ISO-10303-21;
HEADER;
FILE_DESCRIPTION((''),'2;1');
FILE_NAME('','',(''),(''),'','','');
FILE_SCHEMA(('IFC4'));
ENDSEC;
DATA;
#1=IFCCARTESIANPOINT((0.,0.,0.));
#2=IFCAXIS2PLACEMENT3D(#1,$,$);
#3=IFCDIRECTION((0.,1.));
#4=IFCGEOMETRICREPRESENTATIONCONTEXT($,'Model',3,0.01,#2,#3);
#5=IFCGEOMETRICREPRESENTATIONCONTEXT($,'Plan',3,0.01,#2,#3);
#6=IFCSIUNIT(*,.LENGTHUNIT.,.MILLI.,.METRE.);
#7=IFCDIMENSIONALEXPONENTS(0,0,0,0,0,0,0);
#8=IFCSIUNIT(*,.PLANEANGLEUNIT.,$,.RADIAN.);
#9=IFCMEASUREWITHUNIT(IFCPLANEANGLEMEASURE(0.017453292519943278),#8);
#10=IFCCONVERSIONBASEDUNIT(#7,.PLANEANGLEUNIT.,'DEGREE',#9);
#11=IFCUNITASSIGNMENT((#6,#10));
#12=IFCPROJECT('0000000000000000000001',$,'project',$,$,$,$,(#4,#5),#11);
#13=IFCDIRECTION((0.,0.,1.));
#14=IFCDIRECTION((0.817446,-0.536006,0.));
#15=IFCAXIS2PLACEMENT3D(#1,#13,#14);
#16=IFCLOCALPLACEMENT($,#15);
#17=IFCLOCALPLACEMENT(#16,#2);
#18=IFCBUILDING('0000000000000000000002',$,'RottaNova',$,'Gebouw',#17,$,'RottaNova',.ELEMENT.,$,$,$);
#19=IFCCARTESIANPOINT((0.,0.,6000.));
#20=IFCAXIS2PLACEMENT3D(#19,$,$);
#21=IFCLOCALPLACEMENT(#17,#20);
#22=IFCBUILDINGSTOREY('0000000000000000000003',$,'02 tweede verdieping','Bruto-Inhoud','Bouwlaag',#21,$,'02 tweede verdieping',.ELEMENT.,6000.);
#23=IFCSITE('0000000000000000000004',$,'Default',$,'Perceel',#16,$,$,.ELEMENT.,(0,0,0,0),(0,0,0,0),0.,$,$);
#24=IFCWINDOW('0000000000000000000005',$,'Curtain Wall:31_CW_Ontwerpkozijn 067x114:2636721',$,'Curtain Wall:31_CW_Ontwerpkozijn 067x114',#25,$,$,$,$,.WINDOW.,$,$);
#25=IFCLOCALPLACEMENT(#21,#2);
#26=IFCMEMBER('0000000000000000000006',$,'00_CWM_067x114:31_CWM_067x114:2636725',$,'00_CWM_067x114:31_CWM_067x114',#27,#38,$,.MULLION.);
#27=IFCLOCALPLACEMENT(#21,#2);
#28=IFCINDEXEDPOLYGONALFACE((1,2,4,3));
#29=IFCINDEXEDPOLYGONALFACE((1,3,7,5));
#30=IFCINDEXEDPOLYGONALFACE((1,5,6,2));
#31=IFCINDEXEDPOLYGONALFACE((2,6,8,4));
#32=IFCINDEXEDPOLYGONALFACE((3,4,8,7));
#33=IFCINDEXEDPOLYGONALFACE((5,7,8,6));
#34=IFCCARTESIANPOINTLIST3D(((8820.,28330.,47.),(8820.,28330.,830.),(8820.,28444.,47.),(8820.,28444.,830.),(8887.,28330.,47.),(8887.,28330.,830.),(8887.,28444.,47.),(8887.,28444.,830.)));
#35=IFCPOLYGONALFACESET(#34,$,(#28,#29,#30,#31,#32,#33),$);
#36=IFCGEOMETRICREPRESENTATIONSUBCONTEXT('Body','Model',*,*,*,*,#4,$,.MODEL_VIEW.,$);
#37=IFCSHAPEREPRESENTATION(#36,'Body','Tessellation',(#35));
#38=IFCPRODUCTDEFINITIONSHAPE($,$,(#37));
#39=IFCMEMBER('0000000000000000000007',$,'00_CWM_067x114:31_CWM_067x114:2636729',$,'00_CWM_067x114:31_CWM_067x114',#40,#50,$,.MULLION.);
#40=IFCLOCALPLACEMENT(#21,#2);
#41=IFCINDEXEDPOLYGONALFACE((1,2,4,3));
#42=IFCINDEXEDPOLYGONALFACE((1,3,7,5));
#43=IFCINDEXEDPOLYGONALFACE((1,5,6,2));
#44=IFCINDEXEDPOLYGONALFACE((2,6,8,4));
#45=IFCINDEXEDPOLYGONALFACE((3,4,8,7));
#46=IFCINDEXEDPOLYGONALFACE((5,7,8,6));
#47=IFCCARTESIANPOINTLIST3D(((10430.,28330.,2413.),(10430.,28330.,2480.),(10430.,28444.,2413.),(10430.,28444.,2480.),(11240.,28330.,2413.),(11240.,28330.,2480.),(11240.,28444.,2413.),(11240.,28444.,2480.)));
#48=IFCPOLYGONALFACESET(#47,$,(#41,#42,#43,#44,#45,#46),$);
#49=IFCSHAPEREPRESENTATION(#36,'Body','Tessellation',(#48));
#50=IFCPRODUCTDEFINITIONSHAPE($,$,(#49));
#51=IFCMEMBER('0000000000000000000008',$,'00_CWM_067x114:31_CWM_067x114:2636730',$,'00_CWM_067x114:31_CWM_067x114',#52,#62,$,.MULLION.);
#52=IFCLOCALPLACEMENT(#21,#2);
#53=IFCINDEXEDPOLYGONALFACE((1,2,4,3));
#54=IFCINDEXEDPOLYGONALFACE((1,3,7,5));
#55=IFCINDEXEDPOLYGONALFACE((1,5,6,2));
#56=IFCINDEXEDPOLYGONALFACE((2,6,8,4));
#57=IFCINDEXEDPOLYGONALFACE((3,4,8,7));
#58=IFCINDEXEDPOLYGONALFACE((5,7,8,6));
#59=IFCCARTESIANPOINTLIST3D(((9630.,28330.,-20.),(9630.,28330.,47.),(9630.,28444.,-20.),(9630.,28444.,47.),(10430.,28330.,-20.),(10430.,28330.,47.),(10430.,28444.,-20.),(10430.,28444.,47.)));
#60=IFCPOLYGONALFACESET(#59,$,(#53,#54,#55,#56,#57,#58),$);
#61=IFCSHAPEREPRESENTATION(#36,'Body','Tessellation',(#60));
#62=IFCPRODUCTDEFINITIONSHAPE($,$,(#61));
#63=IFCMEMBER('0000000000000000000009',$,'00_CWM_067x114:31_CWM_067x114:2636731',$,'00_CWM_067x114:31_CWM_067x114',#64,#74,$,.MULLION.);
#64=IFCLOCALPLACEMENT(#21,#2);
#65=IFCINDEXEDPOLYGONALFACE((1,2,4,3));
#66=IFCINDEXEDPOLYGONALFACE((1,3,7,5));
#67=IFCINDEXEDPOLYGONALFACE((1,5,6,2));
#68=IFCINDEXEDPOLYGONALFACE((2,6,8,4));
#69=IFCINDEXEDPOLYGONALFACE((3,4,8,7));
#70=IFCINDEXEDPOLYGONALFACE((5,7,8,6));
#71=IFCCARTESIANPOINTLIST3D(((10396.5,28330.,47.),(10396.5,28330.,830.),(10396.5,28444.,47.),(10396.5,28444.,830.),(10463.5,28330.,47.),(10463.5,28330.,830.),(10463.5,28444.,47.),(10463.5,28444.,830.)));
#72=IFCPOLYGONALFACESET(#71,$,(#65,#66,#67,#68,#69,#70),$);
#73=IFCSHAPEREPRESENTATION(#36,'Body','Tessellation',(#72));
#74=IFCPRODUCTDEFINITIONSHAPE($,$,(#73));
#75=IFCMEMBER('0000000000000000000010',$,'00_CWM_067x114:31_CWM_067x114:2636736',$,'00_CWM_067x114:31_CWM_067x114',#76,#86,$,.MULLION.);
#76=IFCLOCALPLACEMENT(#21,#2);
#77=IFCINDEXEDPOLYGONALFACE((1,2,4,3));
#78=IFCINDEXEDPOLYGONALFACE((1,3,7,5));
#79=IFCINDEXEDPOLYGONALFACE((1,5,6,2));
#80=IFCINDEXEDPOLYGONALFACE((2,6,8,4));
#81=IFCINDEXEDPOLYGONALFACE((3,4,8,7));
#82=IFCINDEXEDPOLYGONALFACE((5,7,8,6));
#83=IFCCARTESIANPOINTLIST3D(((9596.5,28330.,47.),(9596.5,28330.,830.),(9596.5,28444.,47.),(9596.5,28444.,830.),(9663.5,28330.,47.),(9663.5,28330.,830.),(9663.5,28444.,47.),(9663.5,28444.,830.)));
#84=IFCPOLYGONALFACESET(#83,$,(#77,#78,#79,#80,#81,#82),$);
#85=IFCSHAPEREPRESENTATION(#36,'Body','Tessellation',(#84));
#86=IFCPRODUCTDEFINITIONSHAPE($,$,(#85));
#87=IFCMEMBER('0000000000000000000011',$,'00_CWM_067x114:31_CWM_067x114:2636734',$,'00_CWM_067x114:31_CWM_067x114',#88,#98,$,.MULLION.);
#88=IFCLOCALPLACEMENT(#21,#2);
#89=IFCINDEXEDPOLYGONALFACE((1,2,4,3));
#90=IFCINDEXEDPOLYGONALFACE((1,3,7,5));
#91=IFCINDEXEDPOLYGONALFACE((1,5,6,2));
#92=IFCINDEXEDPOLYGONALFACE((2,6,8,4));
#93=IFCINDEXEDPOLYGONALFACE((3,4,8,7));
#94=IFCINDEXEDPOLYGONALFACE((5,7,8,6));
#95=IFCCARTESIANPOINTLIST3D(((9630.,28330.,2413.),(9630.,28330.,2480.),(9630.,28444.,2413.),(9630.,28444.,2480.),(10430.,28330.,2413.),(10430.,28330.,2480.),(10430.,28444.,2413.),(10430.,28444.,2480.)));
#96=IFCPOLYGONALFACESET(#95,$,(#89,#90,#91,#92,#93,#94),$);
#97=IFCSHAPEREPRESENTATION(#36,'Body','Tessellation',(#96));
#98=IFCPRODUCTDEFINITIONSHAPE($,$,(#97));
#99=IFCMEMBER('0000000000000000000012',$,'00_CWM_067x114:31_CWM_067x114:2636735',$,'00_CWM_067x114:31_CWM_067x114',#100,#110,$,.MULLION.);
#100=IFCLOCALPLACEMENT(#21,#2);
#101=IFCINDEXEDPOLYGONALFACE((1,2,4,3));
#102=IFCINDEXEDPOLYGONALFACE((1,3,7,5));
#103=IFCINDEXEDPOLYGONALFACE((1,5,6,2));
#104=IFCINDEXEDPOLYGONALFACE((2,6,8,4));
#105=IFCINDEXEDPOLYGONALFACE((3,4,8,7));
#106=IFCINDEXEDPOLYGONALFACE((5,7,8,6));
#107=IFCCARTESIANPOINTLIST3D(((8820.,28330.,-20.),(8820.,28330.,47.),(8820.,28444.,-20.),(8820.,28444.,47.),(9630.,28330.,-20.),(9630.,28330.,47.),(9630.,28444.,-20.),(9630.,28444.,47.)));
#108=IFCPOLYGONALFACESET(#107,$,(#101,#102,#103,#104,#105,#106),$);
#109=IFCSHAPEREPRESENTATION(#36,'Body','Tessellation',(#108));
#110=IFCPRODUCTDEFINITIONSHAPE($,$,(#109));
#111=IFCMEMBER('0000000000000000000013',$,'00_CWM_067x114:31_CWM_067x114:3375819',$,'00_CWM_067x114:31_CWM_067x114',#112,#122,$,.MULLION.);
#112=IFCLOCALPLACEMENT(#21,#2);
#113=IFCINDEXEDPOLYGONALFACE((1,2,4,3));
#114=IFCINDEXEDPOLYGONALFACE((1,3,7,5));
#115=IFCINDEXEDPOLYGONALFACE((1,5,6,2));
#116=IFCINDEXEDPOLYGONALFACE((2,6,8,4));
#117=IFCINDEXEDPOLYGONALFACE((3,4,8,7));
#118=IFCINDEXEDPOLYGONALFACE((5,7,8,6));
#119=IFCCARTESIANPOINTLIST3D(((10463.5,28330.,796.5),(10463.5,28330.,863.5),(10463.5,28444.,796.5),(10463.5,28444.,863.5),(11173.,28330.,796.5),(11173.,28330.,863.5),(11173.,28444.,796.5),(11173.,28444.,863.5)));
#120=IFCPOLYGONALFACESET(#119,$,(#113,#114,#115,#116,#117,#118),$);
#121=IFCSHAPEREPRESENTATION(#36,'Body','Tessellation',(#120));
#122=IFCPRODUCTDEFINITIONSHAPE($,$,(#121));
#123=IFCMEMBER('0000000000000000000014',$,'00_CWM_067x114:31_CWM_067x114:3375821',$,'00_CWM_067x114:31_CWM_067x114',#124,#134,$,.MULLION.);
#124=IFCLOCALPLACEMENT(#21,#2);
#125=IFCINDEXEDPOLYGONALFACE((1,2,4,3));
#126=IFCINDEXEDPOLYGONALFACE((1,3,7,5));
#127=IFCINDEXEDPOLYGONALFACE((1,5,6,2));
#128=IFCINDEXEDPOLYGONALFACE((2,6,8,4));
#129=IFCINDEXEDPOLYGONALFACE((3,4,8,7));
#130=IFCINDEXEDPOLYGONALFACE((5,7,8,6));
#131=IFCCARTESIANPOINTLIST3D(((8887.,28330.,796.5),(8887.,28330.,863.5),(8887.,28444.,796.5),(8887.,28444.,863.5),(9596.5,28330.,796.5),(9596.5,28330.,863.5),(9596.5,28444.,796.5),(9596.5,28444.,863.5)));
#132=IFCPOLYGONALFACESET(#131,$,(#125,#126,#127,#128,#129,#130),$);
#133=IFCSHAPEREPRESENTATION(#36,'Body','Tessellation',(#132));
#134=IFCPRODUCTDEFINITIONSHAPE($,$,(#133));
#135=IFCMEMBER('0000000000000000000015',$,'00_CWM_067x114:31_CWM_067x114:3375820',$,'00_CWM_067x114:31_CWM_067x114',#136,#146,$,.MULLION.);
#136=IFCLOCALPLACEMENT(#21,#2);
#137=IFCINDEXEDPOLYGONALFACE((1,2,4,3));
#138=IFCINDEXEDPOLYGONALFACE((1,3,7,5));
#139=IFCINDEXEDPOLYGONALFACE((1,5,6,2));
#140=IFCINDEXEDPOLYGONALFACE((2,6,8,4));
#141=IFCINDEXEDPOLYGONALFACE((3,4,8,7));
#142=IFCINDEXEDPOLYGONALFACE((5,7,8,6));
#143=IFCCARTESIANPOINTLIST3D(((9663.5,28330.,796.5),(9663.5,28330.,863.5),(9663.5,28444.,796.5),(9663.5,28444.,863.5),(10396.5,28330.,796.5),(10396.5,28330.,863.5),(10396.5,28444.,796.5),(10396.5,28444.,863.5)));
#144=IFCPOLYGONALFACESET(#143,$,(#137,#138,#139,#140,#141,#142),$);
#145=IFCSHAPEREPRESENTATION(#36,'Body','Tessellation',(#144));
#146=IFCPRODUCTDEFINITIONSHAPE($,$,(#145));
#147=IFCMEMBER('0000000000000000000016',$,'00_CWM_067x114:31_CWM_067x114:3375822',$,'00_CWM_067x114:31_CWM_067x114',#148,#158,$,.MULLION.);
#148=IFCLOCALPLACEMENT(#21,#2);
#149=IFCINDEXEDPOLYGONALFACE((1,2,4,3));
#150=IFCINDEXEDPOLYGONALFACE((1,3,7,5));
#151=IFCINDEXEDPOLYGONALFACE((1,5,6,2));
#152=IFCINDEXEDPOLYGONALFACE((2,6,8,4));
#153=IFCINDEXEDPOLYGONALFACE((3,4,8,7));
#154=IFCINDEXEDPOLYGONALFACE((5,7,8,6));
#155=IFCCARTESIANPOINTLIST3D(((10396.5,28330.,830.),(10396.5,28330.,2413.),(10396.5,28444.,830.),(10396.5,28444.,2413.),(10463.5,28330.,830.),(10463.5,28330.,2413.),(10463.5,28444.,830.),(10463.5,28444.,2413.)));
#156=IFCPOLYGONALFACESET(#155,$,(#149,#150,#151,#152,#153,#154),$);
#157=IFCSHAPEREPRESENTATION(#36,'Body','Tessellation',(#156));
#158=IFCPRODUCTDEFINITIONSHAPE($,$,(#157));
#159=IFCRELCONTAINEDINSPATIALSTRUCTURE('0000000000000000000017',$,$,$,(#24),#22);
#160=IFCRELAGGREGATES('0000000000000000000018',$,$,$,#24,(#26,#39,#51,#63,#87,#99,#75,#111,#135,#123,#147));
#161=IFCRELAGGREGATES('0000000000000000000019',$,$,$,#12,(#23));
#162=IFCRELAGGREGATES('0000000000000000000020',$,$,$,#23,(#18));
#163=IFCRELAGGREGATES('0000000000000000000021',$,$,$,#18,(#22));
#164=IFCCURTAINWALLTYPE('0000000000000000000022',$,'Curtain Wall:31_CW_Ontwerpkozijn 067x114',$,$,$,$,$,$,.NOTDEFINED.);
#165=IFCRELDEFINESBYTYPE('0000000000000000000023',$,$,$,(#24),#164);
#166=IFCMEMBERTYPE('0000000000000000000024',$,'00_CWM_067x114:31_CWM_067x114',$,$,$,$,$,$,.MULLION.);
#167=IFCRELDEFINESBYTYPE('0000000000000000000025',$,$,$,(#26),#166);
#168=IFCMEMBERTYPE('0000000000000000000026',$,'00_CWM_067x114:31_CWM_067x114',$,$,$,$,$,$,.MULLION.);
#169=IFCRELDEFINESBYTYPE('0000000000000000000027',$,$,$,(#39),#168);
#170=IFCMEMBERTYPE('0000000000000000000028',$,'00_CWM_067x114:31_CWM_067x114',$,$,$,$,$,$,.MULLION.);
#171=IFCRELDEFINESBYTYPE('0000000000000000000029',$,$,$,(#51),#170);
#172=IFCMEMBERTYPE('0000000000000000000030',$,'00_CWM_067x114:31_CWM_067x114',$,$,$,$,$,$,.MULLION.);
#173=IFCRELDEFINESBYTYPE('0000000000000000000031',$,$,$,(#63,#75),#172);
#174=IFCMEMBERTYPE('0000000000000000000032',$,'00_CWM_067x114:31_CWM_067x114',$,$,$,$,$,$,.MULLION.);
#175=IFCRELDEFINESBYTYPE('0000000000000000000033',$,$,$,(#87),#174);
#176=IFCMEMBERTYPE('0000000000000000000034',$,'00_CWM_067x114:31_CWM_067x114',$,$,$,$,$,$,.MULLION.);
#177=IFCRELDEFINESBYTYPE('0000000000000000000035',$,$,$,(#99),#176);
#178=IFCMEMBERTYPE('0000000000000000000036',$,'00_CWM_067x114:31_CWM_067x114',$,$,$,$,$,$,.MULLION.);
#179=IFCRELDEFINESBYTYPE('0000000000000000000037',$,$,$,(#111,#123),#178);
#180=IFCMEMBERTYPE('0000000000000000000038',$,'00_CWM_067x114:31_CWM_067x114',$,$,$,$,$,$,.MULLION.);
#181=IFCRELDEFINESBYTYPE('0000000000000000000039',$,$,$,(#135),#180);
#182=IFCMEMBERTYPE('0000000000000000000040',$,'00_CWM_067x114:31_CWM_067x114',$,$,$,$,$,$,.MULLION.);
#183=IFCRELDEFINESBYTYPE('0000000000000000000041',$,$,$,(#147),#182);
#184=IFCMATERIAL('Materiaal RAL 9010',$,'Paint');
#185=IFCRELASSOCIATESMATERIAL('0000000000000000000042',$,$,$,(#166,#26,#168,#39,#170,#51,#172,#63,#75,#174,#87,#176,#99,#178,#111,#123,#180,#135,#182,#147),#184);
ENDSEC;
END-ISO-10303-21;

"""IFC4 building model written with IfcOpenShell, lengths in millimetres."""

from ifc_helpers import new_model, entity, si_unit, converted_unit, direction, frame, origin, place, context, subcontext, project, spatial, indexed_curve, outline, extrude, source, transform, mapped, material, type_object, type_shapes, element, aggregate, save


model = new_model("IFC4")

# Units and contexts
model_context = context("Model", 3, precision=0.01, world=origin(), true_north=direction((0.0, 1.0)))
plan_context = context("Plan", 3, precision=0.01, world=origin(), true_north=direction((0.0, 1.0)))
body_context = subcontext(model_context, "Body", "Model", "MODEL_VIEW")
ifc_project = project(units=[si_unit("LENGTHUNIT", "METRE", prefix="MILLI"), converted_unit("PLANEANGLEUNIT", "DEGREE", entity("IfcPlaneAngleMeasure", 0.017453292519943278), si_unit("PLANEANGLEUNIT", "RADIAN"), dimensions=[0, 0, 0, 0, 0, 0, 0])], contexts=[model_context, plan_context])

# Site, building, storey
site_placement = place(None, frame((0.0, 0.0, 0.0), z_axis=(0.0, 0.0, 1.0), x_axis=(0.817446, -0.536006, 0.0)))
site = spatial("IfcSite", under=ifc_project, at=site_placement, Name="Default", ObjectType="Perceel", CompositionType="ELEMENT", RefLatitude=(0, 0, 0, 0), RefLongitude=(0, 0, 0, 0), RefElevation=0.0)
building_placement = place(site_placement, origin())
building = spatial("IfcBuilding", under=site, at=building_placement, Name="RottaNova", ObjectType="Gebouw", LongName="RottaNova", CompositionType="ELEMENT")
storey_placement = place(building_placement, frame((0.0, 0.0, 6000.0)))
storey = spatial("IfcBuildingStorey", under=building, at=storey_placement, Name="02 tweede verdieping", Description="Bruto-Inhoud", ObjectType="Bouwlaag", LongName="02 tweede verdieping", CompositionType="ELEMENT", Elevation=6000.0)

# Window, members
curtain_wall_type = type_object("IfcCurtainWallType", Name="Curtain Wall:31_CW_Ontwerpkozijn 067x114", PredefinedType="NOTDEFINED")
window_1_placement = place(storey_placement, frame((0.0, 0.0, -6000.0)))
window_1 = element("IfcWindow", 1, at=window_1_placement, inside=storey, type_object=curtain_wall_type, Name="Curtain Wall:31_CW_Ontwerpkozijn 067x114:2636721", ObjectType="Curtain Wall:31_CW_Ontwerpkozijn 067x114", PredefinedType="WINDOW")
ifc_material_1 = material(Name="Materiaal RAL 9010", Category="Paint")
member_type_1 = type_object("IfcMemberType", Name="00_CWM_067x114:31_CWM_067x114", PredefinedType="MULLION", material=ifc_material_1)
shared_shape_1 = source(origin(), body_context, "Body", "SweptSolid", [
    extrude(outline(indexed_curve([(-33.5, -57.0), (33.5, -57.0), (33.5, 57.0), (-33.5, 57.0), (-33.5, -57.0)], self_intersect=False)), frame((-33.5, 57.0, -783.0), z_axis=(0.0, 0.0, 1.0), x_axis=(-1.0, 0.0, 0.0)), (0.0, 0.0, 1.0), 783.0),
])
type_shapes(member_type_1, [shared_shape_1])
member_1_placement = place(window_1_placement, frame((8820.0, 28330.0, 6047.0), z_axis=(0.0, 0.0, -1.0), x_axis=(-1.0, 0.0, 0.0)))
member_1 = element("IfcMember", 2, at=member_1_placement, type_object=member_type_1, material=ifc_material_1, Name="00_CWM_067x114:31_CWM_067x114:2636725", ObjectType="00_CWM_067x114:31_CWM_067x114", PredefinedType="MULLION", context=body_context, shape_type="MappedRepresentation", body=[
    mapped(shared_shape_1, transform((0.0, 0.0, 0.0), scale=1.0)),
])
member_type_2 = type_object("IfcMemberType", Name="00_CWM_067x114:31_CWM_067x114", PredefinedType="MULLION", material=ifc_material_1)
shared_shape_2 = source(origin(), body_context, "Body", "SweptSolid", [
    extrude(outline(indexed_curve([(-33.5, -57.0), (33.5, -57.0), (33.5, 57.0), (-33.5, 57.0), (-33.5, -57.0)], self_intersect=False)), frame((-33.5, 57.0, -810.0), z_axis=(0.0, 0.0, 1.0), x_axis=(-1.0, 0.0, 0.0)), (0.0, 0.0, 1.0), 810.0),
])
type_shapes(member_type_2, [shared_shape_2])
member_2_placement = place(window_1_placement, frame((10430.0, 28330.0, 8480.0), z_axis=(-1.0, 0.0, 0.0), x_axis=(0.0, 0.0, 1.0)))
member_2 = element("IfcMember", 3, at=member_2_placement, type_object=member_type_2, material=ifc_material_1, Name="00_CWM_067x114:31_CWM_067x114:2636729", ObjectType="00_CWM_067x114:31_CWM_067x114", PredefinedType="MULLION", context=body_context, shape_type="MappedRepresentation", body=[
    mapped(shared_shape_2, transform((0.0, 0.0, 0.0), scale=1.0)),
])
member_type_3 = type_object("IfcMemberType", Name="00_CWM_067x114:31_CWM_067x114", PredefinedType="MULLION", material=ifc_material_1)
shared_shape_3 = source(origin(), body_context, "Body", "SweptSolid", [
    extrude(outline(indexed_curve([(-33.5, -57.0), (33.5, -57.0), (33.5, 57.0), (-33.5, 57.0), (-33.5, -57.0)], self_intersect=False)), frame((-33.5, 57.0, -800.0), z_axis=(0.0, 0.0, 1.0), x_axis=(-1.0, 0.0, 0.0)), (0.0, 0.0, 1.0), 800.0),
])
type_shapes(member_type_3, [shared_shape_3])
member_3_placement = place(window_1_placement, frame((10430.0, 28330.0, 5980.0), z_axis=(1.0, 0.0, 0.0), x_axis=(0.0, 0.0, -1.0)))
member_3 = element("IfcMember", 4, at=member_3_placement, type_object=member_type_3, material=ifc_material_1, Name="00_CWM_067x114:31_CWM_067x114:2636730", ObjectType="00_CWM_067x114:31_CWM_067x114", PredefinedType="MULLION", context=body_context, shape_type="MappedRepresentation", body=[
    mapped(shared_shape_3, transform((0.0, 0.0, 0.0), scale=1.0)),
])
member_type_4 = type_object("IfcMemberType", Name="00_CWM_067x114:31_CWM_067x114", PredefinedType="MULLION", material=ifc_material_1)
shared_shape_4 = source(origin(), body_context, "Body", "SweptSolid", [
    extrude(outline(indexed_curve([(-33.5, -57.0), (33.5, -57.0), (33.5, 57.0), (-33.5, 57.0), (-33.5, -57.0)], self_intersect=False)), frame((0.0, 57.0, -783.0), z_axis=(0.0, 0.0, 1.0), x_axis=(-1.0, 0.0, 0.0)), (0.0, 0.0, 1.0), 783.0),
])
type_shapes(member_type_4, [shared_shape_4])
member_4_placement = place(window_1_placement, frame((10430.0, 28330.0, 6047.0), z_axis=(0.0, 0.0, -1.0), x_axis=(-1.0, 0.0, 0.0)))
member_4 = element("IfcMember", 5, at=member_4_placement, type_object=member_type_4, material=ifc_material_1, Name="00_CWM_067x114:31_CWM_067x114:2636731", ObjectType="00_CWM_067x114:31_CWM_067x114", PredefinedType="MULLION", context=body_context, shape_type="MappedRepresentation", body=[
    mapped(shared_shape_4, transform((0.0, 0.0, 0.0), scale=1.0)),
])
member_5_placement = place(window_1_placement, frame((9630.0, 28330.0, 6047.0), z_axis=(0.0, 0.0, -1.0), x_axis=(-1.0, 0.0, 0.0)))
member_5 = element("IfcMember", 6, at=member_5_placement, type_object=member_type_4, material=ifc_material_1, Name="00_CWM_067x114:31_CWM_067x114:2636736", ObjectType="00_CWM_067x114:31_CWM_067x114", PredefinedType="MULLION", context=body_context, shape_type="MappedRepresentation", body=[
    mapped(shared_shape_4, transform((0.0, 0.0, 0.0), scale=1.0)),
])
member_type_5 = type_object("IfcMemberType", Name="00_CWM_067x114:31_CWM_067x114", PredefinedType="MULLION", material=ifc_material_1)
shared_shape_5 = source(origin(), body_context, "Body", "SweptSolid", [
    extrude(outline(indexed_curve([(-33.5, -57.0), (33.5, -57.0), (33.5, 57.0), (-33.5, 57.0), (-33.5, -57.0)], self_intersect=False)), frame((-33.5, 57.0, -800.0), z_axis=(0.0, 0.0, 1.0), x_axis=(-1.0, 0.0, 0.0)), (0.0, 0.0, 1.0), 800.0),
])
type_shapes(member_type_5, [shared_shape_5])
member_6_placement = place(window_1_placement, frame((9630.0, 28330.0, 8480.0), z_axis=(-1.0, 0.0, 0.0), x_axis=(0.0, 0.0, 1.0)))
member_6 = element("IfcMember", 7, at=member_6_placement, type_object=member_type_5, material=ifc_material_1, Name="00_CWM_067x114:31_CWM_067x114:2636734", ObjectType="00_CWM_067x114:31_CWM_067x114", PredefinedType="MULLION", context=body_context, shape_type="MappedRepresentation", body=[
    mapped(shared_shape_5, transform((0.0, 0.0, 0.0), scale=1.0)),
])
member_type_6 = type_object("IfcMemberType", Name="00_CWM_067x114:31_CWM_067x114", PredefinedType="MULLION", material=ifc_material_1)
shared_shape_6 = source(origin(), body_context, "Body", "SweptSolid", [
    extrude(outline(indexed_curve([(-33.5, -57.0), (33.5, -57.0), (33.5, 57.0), (-33.5, 57.0), (-33.5, -57.0)], self_intersect=False)), frame((-33.5, 57.0, -810.0), z_axis=(0.0, 0.0, 1.0), x_axis=(-1.0, 0.0, 0.0)), (0.0, 0.0, 1.0), 810.0),
])
type_shapes(member_type_6, [shared_shape_6])
member_7_placement = place(window_1_placement, frame((9630.0, 28330.0, 5980.0), z_axis=(1.0, 0.0, 0.0), x_axis=(0.0, 0.0, -1.0)))
member_7 = element("IfcMember", 8, at=member_7_placement, type_object=member_type_6, material=ifc_material_1, Name="00_CWM_067x114:31_CWM_067x114:2636735", ObjectType="00_CWM_067x114:31_CWM_067x114", PredefinedType="MULLION", context=body_context, shape_type="MappedRepresentation", body=[
    mapped(shared_shape_6, transform((0.0, 0.0, 0.0), scale=1.0)),
])
member_type_7 = type_object("IfcMemberType", Name="00_CWM_067x114:31_CWM_067x114", PredefinedType="MULLION", material=ifc_material_1)
shared_shape_7 = source(origin(), body_context, "Body", "SweptSolid", [
    extrude(outline(indexed_curve([(-33.5, -57.0), (33.5, -57.0), (33.5, 57.0), (-33.5, 57.0), (-33.5, -57.0)], self_intersect=False)), frame((0.0, 57.0, -709.5), z_axis=(0.0, 0.0, 1.0), x_axis=(-1.0, 0.0, 0.0)), (0.0, 0.0, 1.0), 709.5),
])
type_shapes(member_type_7, [shared_shape_7])
member_8_placement = place(window_1_placement, frame((10463.5, 28330.0, 6830.0), z_axis=(-1.0, 0.0, 0.0), x_axis=(0.0, 0.0, 1.0)))
member_8 = element("IfcMember", 9, at=member_8_placement, type_object=member_type_7, material=ifc_material_1, Name="00_CWM_067x114:31_CWM_067x114:3375819", ObjectType="00_CWM_067x114:31_CWM_067x114", PredefinedType="MULLION", context=body_context, shape_type="MappedRepresentation", body=[
    mapped(shared_shape_7, transform((0.0, 0.0, 0.0), scale=1.0)),
])
member_9_placement = place(window_1_placement, frame((8887.0, 28330.0, 6830.0), z_axis=(-1.0, 0.0, 0.0), x_axis=(0.0, 0.0, 1.0)))
member_9 = element("IfcMember", 10, at=member_9_placement, type_object=member_type_7, material=ifc_material_1, Name="00_CWM_067x114:31_CWM_067x114:3375821", ObjectType="00_CWM_067x114:31_CWM_067x114", PredefinedType="MULLION", context=body_context, shape_type="MappedRepresentation", body=[
    mapped(shared_shape_7, transform((0.0, 0.0, 0.0), scale=1.0)),
])
member_type_8 = type_object("IfcMemberType", Name="00_CWM_067x114:31_CWM_067x114", PredefinedType="MULLION", material=ifc_material_1)
shared_shape_8 = source(origin(), body_context, "Body", "SweptSolid", [
    extrude(outline(indexed_curve([(-33.5, -57.0), (33.5, -57.0), (33.5, 57.0), (-33.5, 57.0), (-33.5, -57.0)], self_intersect=False)), frame((0.0, 57.0, -733.0), z_axis=(0.0, 0.0, 1.0), x_axis=(-1.0, 0.0, 0.0)), (0.0, 0.0, 1.0), 733.0),
])
type_shapes(member_type_8, [shared_shape_8])
member_10_placement = place(window_1_placement, frame((9663.5, 28330.0, 6830.0), z_axis=(-1.0, 0.0, 0.0), x_axis=(0.0, 0.0, 1.0)))
member_10 = element("IfcMember", 11, at=member_10_placement, type_object=member_type_8, material=ifc_material_1, Name="00_CWM_067x114:31_CWM_067x114:3375820", ObjectType="00_CWM_067x114:31_CWM_067x114", PredefinedType="MULLION", context=body_context, shape_type="MappedRepresentation", body=[
    mapped(shared_shape_8, transform((0.0, 0.0, 0.0), scale=1.0)),
])
member_type_9 = type_object("IfcMemberType", Name="00_CWM_067x114:31_CWM_067x114", PredefinedType="MULLION", material=ifc_material_1)
shared_shape_9 = source(origin(), body_context, "Body", "SweptSolid", [
    extrude(outline(indexed_curve([(-33.5, -57.0), (33.5, -57.0), (33.5, 57.0), (-33.5, 57.0), (-33.5, -57.0)], self_intersect=False)), frame((0.0, 57.0, -1583.0), z_axis=(0.0, 0.0, 1.0), x_axis=(-1.0, 0.0, 0.0)), (0.0, 0.0, 1.0), 1583.0),
])
type_shapes(member_type_9, [shared_shape_9])
member_11_placement = place(window_1_placement, frame((10430.0, 28330.0, 6830.0), z_axis=(0.0, 0.0, -1.0), x_axis=(-1.0, 0.0, 0.0)))
member_11 = element("IfcMember", 12, at=member_11_placement, type_object=member_type_9, material=ifc_material_1, Name="00_CWM_067x114:31_CWM_067x114:3375822", ObjectType="00_CWM_067x114:31_CWM_067x114", PredefinedType="MULLION", context=body_context, shape_type="MappedRepresentation", body=[
    mapped(shared_shape_9, transform((0.0, 0.0, 0.0), scale=1.0)),
])

aggregate(window_1, [member_1, member_2, member_3, member_4, member_6, member_7, member_5, member_8, member_10, member_9, member_11])

save(model, "model.ifc")
